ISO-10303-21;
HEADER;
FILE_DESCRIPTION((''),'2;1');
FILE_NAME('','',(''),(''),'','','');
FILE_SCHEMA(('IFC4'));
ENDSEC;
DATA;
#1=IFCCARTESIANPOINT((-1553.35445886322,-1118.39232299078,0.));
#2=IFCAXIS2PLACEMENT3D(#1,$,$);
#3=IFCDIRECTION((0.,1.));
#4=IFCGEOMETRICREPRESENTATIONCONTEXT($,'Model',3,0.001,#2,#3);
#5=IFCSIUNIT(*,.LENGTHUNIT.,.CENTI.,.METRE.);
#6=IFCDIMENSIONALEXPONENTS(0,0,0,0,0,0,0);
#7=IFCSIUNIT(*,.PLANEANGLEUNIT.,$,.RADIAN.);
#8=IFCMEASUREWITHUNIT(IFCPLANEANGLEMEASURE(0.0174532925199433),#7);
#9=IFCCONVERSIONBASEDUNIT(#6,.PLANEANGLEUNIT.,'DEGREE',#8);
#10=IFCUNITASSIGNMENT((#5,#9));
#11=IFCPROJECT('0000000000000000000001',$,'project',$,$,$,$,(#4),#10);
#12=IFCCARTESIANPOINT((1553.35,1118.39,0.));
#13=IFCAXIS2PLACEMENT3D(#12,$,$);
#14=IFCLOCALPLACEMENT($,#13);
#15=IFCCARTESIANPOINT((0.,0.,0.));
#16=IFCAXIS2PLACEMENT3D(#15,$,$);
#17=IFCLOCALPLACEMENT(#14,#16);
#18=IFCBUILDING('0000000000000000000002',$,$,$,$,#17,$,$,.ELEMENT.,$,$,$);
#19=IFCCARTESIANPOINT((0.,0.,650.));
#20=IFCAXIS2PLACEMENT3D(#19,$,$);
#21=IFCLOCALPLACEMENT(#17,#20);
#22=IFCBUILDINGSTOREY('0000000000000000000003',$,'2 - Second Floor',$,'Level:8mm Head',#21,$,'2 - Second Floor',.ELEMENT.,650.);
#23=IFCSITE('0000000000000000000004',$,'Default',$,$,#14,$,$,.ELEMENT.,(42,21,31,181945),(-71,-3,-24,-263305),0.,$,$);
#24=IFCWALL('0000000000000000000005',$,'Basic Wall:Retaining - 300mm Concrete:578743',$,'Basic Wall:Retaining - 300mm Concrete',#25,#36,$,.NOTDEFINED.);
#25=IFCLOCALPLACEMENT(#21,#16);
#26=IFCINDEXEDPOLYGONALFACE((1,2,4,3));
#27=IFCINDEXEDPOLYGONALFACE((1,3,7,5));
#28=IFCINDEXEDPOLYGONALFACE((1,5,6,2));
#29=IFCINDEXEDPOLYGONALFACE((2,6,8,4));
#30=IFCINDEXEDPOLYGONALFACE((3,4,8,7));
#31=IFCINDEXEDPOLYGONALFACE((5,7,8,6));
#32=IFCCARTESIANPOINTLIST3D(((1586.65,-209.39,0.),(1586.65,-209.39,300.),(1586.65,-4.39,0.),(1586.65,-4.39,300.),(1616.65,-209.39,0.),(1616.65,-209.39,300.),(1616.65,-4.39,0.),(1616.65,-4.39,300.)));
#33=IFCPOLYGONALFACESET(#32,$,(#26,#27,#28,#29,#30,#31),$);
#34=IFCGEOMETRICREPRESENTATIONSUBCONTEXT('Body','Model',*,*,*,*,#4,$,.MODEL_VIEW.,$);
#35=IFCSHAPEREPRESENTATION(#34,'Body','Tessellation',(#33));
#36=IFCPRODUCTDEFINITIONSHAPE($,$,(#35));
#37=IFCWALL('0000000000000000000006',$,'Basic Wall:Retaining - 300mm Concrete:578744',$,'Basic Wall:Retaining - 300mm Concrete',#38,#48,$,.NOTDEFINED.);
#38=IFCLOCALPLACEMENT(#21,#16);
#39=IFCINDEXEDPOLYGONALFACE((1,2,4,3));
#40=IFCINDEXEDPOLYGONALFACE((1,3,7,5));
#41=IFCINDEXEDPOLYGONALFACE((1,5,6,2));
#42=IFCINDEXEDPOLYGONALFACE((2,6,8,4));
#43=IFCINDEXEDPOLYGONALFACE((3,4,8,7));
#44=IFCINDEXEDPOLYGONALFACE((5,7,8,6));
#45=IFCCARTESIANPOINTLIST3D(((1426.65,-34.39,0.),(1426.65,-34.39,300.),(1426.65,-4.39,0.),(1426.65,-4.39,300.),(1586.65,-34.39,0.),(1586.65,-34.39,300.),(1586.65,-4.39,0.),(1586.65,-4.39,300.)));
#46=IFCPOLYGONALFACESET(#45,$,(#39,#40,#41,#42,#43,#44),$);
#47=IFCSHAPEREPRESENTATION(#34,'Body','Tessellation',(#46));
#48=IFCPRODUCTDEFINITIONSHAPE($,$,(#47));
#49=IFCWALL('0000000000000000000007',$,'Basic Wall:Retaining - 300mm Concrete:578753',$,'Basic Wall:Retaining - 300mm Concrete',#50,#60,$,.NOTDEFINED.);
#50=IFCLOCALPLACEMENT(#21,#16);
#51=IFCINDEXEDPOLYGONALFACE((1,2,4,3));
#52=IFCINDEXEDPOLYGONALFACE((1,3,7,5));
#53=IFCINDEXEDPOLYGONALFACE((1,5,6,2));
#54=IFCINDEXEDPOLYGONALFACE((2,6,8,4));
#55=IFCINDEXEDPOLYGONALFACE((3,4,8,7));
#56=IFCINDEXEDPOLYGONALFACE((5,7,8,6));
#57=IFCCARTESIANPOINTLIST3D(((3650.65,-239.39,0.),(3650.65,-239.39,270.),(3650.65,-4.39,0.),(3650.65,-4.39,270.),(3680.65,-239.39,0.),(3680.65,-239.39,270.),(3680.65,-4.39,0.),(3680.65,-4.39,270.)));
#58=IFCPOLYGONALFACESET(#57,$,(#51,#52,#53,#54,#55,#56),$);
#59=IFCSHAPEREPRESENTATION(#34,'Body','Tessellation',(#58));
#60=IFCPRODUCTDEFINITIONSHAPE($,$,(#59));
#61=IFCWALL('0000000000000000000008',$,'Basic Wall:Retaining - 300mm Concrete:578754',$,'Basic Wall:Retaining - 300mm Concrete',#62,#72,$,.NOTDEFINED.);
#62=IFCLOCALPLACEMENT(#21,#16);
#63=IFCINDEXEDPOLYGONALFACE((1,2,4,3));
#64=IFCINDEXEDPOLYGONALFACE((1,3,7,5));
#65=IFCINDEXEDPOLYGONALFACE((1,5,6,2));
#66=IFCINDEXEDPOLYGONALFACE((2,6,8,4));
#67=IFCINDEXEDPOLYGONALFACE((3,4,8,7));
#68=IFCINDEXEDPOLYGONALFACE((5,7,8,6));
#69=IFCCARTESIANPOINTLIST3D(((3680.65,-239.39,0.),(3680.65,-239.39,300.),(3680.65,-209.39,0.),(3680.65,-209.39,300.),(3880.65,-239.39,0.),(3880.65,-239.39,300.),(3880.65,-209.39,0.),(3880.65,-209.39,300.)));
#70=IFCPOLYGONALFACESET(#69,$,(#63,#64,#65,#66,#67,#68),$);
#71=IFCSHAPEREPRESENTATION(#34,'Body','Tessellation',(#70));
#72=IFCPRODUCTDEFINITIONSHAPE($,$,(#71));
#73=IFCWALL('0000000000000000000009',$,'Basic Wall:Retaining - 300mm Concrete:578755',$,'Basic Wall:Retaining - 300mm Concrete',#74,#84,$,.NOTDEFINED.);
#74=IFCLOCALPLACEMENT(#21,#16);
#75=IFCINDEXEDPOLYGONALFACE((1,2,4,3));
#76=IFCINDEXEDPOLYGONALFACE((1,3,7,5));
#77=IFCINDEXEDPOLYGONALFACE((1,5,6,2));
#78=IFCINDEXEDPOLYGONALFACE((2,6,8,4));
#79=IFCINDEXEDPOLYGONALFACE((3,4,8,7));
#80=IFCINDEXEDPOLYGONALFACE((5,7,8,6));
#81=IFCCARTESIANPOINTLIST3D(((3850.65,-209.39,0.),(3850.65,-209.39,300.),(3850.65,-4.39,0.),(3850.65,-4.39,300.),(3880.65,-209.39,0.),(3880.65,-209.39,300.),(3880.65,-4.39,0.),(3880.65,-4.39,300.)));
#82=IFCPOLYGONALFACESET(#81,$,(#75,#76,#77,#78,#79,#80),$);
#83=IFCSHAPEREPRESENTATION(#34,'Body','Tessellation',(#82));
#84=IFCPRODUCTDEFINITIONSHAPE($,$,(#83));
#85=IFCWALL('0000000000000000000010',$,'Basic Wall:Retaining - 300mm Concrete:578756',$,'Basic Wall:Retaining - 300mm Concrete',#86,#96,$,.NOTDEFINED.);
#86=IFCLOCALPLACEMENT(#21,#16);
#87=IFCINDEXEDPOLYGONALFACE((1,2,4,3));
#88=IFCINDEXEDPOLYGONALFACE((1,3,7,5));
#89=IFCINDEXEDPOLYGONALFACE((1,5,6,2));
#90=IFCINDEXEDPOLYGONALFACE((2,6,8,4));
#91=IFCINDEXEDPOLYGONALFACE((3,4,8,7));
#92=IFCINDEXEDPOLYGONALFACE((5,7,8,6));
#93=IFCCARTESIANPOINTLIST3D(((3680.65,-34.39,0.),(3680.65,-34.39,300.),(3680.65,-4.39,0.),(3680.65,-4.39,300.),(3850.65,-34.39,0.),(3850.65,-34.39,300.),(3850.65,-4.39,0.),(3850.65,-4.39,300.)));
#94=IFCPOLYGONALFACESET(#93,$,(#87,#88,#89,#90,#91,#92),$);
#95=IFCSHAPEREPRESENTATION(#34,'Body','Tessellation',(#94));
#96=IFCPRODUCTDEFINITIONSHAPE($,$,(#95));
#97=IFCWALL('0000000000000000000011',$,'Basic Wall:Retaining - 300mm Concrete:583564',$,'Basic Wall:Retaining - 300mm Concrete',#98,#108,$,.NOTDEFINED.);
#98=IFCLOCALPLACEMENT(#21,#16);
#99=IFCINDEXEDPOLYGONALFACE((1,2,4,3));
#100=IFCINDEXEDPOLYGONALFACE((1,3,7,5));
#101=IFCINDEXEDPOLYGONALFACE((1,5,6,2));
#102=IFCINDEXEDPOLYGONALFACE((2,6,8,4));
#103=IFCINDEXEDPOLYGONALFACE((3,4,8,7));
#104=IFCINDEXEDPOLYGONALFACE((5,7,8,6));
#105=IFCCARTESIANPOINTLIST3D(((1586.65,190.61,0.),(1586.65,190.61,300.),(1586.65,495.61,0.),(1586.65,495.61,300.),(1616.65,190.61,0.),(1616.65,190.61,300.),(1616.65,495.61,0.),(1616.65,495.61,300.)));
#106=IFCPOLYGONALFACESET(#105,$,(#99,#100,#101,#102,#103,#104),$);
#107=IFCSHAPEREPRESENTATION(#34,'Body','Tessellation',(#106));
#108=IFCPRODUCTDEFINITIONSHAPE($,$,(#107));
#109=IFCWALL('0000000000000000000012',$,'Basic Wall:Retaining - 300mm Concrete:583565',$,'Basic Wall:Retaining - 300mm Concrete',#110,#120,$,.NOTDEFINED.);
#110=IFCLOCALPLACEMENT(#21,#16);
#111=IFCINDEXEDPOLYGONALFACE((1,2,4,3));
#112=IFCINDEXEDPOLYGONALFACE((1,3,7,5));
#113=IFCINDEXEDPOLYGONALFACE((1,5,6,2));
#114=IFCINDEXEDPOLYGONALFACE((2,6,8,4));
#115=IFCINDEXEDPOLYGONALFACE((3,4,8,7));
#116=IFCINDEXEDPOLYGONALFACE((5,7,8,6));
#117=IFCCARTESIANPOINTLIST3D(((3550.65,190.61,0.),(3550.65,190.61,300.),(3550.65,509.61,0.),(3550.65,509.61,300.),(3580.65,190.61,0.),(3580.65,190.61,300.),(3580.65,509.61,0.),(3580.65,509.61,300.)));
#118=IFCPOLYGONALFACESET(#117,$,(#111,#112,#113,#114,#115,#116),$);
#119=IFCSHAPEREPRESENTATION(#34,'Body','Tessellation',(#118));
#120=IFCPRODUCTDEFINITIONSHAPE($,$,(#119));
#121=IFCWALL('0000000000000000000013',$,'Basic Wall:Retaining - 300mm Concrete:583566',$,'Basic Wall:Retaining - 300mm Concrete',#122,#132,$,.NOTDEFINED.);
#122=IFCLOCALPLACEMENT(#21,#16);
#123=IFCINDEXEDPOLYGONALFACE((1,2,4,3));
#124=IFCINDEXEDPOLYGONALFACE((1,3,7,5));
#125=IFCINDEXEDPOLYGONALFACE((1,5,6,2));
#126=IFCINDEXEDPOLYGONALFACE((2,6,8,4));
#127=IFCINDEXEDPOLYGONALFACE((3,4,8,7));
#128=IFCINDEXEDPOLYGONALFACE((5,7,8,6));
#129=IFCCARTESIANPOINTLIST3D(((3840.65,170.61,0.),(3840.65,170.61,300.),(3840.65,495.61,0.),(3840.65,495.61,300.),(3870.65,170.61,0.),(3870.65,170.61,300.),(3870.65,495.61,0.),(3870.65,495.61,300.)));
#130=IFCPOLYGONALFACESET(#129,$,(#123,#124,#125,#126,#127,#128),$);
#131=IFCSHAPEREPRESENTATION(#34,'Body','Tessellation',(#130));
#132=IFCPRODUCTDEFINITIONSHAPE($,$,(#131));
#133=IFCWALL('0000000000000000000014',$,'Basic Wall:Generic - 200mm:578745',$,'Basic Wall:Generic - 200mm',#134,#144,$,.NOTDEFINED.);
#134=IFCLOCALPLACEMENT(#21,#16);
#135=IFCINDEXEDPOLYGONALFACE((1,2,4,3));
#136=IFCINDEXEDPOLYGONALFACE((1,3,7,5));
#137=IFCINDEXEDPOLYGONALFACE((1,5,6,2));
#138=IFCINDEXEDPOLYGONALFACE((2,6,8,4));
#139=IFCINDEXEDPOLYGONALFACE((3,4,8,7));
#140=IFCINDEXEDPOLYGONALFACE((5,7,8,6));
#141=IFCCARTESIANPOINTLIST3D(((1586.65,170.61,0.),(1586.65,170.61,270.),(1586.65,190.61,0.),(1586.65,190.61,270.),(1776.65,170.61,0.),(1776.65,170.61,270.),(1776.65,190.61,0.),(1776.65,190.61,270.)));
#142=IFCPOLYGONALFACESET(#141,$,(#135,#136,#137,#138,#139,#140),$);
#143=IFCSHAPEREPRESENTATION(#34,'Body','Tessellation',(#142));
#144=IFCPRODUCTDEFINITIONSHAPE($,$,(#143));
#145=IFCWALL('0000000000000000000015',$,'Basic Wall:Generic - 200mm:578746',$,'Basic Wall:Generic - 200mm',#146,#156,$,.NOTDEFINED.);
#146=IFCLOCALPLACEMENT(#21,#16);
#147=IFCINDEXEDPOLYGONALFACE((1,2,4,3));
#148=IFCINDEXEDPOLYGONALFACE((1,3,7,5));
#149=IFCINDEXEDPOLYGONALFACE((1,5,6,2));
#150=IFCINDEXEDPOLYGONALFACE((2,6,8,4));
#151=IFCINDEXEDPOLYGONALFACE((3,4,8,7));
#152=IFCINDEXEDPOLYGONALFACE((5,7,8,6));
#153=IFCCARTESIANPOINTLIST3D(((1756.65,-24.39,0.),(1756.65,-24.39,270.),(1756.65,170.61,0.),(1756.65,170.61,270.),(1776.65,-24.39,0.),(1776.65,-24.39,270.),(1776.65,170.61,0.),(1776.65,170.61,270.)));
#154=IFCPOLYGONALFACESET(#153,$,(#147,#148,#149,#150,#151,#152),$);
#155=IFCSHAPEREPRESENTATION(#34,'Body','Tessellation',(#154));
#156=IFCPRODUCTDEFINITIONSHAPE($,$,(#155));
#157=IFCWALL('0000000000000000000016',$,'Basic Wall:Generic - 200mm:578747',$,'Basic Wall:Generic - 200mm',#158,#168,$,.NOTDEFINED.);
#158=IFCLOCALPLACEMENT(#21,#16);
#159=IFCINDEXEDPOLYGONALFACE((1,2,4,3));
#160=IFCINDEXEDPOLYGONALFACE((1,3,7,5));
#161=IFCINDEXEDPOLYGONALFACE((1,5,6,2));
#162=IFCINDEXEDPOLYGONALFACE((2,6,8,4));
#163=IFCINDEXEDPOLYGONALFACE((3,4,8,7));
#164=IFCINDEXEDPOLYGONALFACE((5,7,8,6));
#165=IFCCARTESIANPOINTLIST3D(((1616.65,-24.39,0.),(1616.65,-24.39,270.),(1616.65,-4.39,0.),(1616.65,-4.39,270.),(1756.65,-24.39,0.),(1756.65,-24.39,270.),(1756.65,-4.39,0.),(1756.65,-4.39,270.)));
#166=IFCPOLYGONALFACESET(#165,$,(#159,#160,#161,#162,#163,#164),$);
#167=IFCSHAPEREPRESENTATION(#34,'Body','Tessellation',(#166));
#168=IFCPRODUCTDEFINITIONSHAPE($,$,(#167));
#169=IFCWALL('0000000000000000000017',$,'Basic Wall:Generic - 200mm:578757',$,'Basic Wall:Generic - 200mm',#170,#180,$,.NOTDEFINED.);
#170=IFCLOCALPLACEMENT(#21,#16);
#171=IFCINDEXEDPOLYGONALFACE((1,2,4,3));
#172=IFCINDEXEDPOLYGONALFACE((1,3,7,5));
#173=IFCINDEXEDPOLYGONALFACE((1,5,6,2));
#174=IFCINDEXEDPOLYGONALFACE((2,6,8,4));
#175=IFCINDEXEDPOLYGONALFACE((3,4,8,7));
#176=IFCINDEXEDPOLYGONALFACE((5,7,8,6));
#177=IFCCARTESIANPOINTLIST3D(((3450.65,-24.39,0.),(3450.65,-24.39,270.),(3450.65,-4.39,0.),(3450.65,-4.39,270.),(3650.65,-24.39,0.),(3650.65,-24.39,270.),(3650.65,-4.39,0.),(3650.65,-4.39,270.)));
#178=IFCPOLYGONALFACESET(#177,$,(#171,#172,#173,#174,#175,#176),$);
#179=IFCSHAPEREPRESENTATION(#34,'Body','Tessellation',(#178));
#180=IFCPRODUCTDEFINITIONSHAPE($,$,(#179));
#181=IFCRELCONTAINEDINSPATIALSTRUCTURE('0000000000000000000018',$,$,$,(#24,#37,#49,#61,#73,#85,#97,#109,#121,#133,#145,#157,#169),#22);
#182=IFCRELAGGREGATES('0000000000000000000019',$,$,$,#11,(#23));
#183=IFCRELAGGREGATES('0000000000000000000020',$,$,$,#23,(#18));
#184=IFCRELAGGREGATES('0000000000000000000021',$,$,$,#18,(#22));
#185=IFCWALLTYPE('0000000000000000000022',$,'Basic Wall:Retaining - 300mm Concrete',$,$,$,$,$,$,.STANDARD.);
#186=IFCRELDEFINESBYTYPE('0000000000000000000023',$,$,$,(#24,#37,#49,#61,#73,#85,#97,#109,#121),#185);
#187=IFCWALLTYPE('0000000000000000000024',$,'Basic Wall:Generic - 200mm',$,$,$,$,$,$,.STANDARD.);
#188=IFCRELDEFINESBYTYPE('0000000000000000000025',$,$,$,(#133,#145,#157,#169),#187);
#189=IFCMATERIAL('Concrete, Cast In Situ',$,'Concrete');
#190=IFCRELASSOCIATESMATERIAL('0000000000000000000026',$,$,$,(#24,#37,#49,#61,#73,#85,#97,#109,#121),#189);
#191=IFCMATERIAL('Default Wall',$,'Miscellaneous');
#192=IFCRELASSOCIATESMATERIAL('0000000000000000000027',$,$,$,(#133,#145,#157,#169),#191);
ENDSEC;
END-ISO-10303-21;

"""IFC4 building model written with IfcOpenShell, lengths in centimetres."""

from ifc_helpers import new_model, entity, si_unit, converted_unit, direction, frame, origin, place, context, subcontext, project, spatial, indexed_curve, outline, extrude, material, type_object, element, save


model = new_model("IFC4")

# Units and contexts
model_context = context("Model", 3, precision=0.001, world=frame((-1553.35445886322, -1118.39232299078, 0.0)), true_north=direction((0.0, 1.0)))
body_context = subcontext(model_context, "Body", "Model", "MODEL_VIEW")
ifc_project = project(units=[si_unit("LENGTHUNIT", "METRE", prefix="CENTI"), converted_unit("PLANEANGLEUNIT", "DEGREE", entity("IfcPlaneAngleMeasure", 0.0174532925199433), si_unit("PLANEANGLEUNIT", "RADIAN"), dimensions=[0, 0, 0, 0, 0, 0, 0])], contexts=[model_context])

# Site, building, storey
site_placement = place(None, frame((1553.35, 1118.39, 0.0)))
site = spatial("IfcSite", under=ifc_project, at=site_placement, Name="Default", CompositionType="ELEMENT", RefLatitude=(42, 21, 31, 181945), RefLongitude=(-71, -3, -24, -263305), RefElevation=0.0)
building_placement = place(site_placement, origin())
building = spatial("IfcBuilding", under=site, at=building_placement, CompositionType="ELEMENT")
storey_placement = place(building_placement, frame((0.0, 0.0, 650.0)))
storey = spatial("IfcBuildingStorey", under=building, at=storey_placement, Name="2 - Second Floor", ObjectType="Level:8mm Head", LongName="2 - Second Floor", CompositionType="ELEMENT", Elevation=650.0)

# Walls
ifc_material_1 = material(Name="Concrete, Cast In Situ", Category="Concrete")
wall_type_1 = type_object("IfcWallType", Name="Basic Wall:Retaining - 300mm Concrete", PredefinedType="STANDARD")
wall_1_placement = place(storey_placement, frame((1601.65, -209.39, 0.0), z_axis=(0.0, 0.0, 1.0), x_axis=(0.0, 1.0, 0.0)))
element("IfcWall", 1, at=wall_1_placement, inside=storey, type_object=wall_type_1, material=ifc_material_1, Name="Basic Wall:Retaining - 300mm Concrete:578743", ObjectType="Basic Wall:Retaining - 300mm Concrete", PredefinedType="NOTDEFINED", context=body_context, shape_type="SweptSolid", body=[
    extrude(outline(indexed_curve([(205.0, 15.0), (0.0, 15.0), (0.0, -15.0), (205.0, -15.0), (205.0, 15.0)], self_intersect=False)), origin(), (0.0, 0.0, 1.0), 300.0),
])
wall_2_placement = place(storey_placement, frame((1586.65, -19.39, 0.0), z_axis=(0.0, 0.0, 1.0), x_axis=(-1.0, 0.0, 0.0)))
element("IfcWall", 2, at=wall_2_placement, inside=storey, type_object=wall_type_1, material=ifc_material_1, Name="Basic Wall:Retaining - 300mm Concrete:578744", ObjectType="Basic Wall:Retaining - 300mm Concrete", PredefinedType="NOTDEFINED", context=body_context, shape_type="SweptSolid", body=[
    extrude(outline(indexed_curve([(160.0, 15.0), (0.0, 15.0), (0.0, -15.0), (160.0, -15.0), (160.0, 15.0)], self_intersect=False)), origin(), (0.0, 0.0, 1.0), 300.0),
])
wall_3_placement = place(storey_placement, frame((3665.65, -4.39, 0.0), z_axis=(0.0, 0.0, 1.0), x_axis=(0.0, -1.0, 0.0)))
element("IfcWall", 3, at=wall_3_placement, inside=storey, type_object=wall_type_1, material=ifc_material_1, Name="Basic Wall:Retaining - 300mm Concrete:578753", ObjectType="Basic Wall:Retaining - 300mm Concrete", PredefinedType="NOTDEFINED", context=body_context, shape_type="SweptSolid", body=[
    extrude(outline(indexed_curve([(235.0, 15.0), (0.0, 15.0), (0.0, -15.0), (235.0, -15.0), (235.0, 15.0)], self_intersect=False)), origin(), (0.0, 0.0, 1.0), 270.0),
])
wall_4_placement = place(storey_placement, frame((3680.65, -224.39, 0.0)))
element("IfcWall", 4, at=wall_4_placement, inside=storey, type_object=wall_type_1, material=ifc_material_1, Name="Basic Wall:Retaining - 300mm Concrete:578754", ObjectType="Basic Wall:Retaining - 300mm Concrete", PredefinedType="NOTDEFINED", context=body_context, shape_type="SweptSolid", body=[
    extrude(outline(indexed_curve([(200.0, 15.0), (0.0, 15.0), (0.0, -15.0), (200.0, -15.0), (200.0, 15.0)], self_intersect=False)), origin(), (0.0, 0.0, 1.0), 300.0),
])
wall_5_placement = place(storey_placement, frame((3865.65, -209.39, 0.0), z_axis=(0.0, 0.0, 1.0), x_axis=(0.0, 1.0, 0.0)))
element("IfcWall", 5, at=wall_5_placement, inside=storey, type_object=wall_type_1, material=ifc_material_1, Name="Basic Wall:Retaining - 300mm Concrete:578755", ObjectType="Basic Wall:Retaining - 300mm Concrete", PredefinedType="NOTDEFINED", context=body_context, shape_type="SweptSolid", body=[
    extrude(outline(indexed_curve([(205.0, 15.0), (0.0, 15.0), (0.0, -15.0), (205.0, -15.0), (205.0, 15.0)], self_intersect=False)), origin(), (0.0, 0.0, 1.0), 300.0),
])
wall_6_placement = place(storey_placement, frame((3850.65, -19.39, 0.0), z_axis=(0.0, 0.0, 1.0), x_axis=(-1.0, 0.0, 0.0)))
element("IfcWall", 6, at=wall_6_placement, inside=storey, type_object=wall_type_1, material=ifc_material_1, Name="Basic Wall:Retaining - 300mm Concrete:578756", ObjectType="Basic Wall:Retaining - 300mm Concrete", PredefinedType="NOTDEFINED", context=body_context, shape_type="SweptSolid", body=[
    extrude(outline(indexed_curve([(170.0, 15.0), (0.0, 15.0), (0.0, -15.0), (170.0, -15.0), (170.0, 15.0)], self_intersect=False)), origin(), (0.0, 0.0, 1.0), 300.0),
])
wall_7_placement = place(storey_placement, frame((1601.65, 495.61, 0.0), z_axis=(0.0, 0.0, 1.0), x_axis=(0.0, -1.0, 0.0)))
element("IfcWall", 7, at=wall_7_placement, inside=storey, type_object=wall_type_1, material=ifc_material_1, Name="Basic Wall:Retaining - 300mm Concrete:583564", ObjectType="Basic Wall:Retaining - 300mm Concrete", PredefinedType="NOTDEFINED", context=body_context, shape_type="SweptSolid", body=[
    extrude(outline(indexed_curve([(305.0, 15.0), (0.0, 15.0), (0.0, -15.0), (305.0, -15.0), (305.0, 15.0)], self_intersect=False)), origin(), (0.0, 0.0, 1.0), 300.0),
])
wall_8_placement = place(storey_placement, frame((3565.65, 509.61, 0.0), z_axis=(0.0, 0.0, 1.0), x_axis=(0.0, -1.0, 0.0)))
element("IfcWall", 8, at=wall_8_placement, inside=storey, type_object=wall_type_1, material=ifc_material_1, Name="Basic Wall:Retaining - 300mm Concrete:583565", ObjectType="Basic Wall:Retaining - 300mm Concrete", PredefinedType="NOTDEFINED", context=body_context, shape_type="SweptSolid", body=[
    extrude(outline(indexed_curve([(319.0, 15.0), (0.0, 15.0), (0.0, -15.0), (319.0, -15.0), (319.0, 15.0)], self_intersect=False)), origin(), (0.0, 0.0, 1.0), 300.0),
])
wall_9_placement = place(storey_placement, frame((3855.65, 495.61, 0.0), z_axis=(0.0, 0.0, 1.0), x_axis=(0.0, -1.0, 0.0)))
element("IfcWall", 9, at=wall_9_placement, inside=storey, type_object=wall_type_1, material=ifc_material_1, Name="Basic Wall:Retaining - 300mm Concrete:583566", ObjectType="Basic Wall:Retaining - 300mm Concrete", PredefinedType="NOTDEFINED", context=body_context, shape_type="SweptSolid", body=[
    extrude(outline(indexed_curve([(325.0, 15.0), (0.0, 15.0), (0.0, -15.0), (325.0, -15.0), (325.0, 15.0)], self_intersect=False)), origin(), (0.0, 0.0, 1.0), 300.0),
])
ifc_material_2 = material(Name="Default Wall", Category="Miscellaneous")
wall_type_2 = type_object("IfcWallType", Name="Basic Wall:Generic - 200mm", PredefinedType="STANDARD")
wall_10_placement = place(storey_placement, frame((1586.65, 180.61, 0.0)))
element("IfcWall", 10, at=wall_10_placement, inside=storey, type_object=wall_type_2, material=ifc_material_2, Name="Basic Wall:Generic - 200mm:578745", ObjectType="Basic Wall:Generic - 200mm", PredefinedType="NOTDEFINED", context=body_context, shape_type="SweptSolid", body=[
    extrude(outline(indexed_curve([(190.0, 10.0), (0.0, 10.0), (0.0, -10.0), (190.0, -10.0), (190.0, 10.0)], self_intersect=False)), origin(), (0.0, 0.0, 1.0), 270.0),
])
wall_11_placement = place(storey_placement, frame((1766.65, 170.61, 0.0), z_axis=(0.0, 0.0, 1.0), x_axis=(0.0, -1.0, 0.0)))
element("IfcWall", 11, at=wall_11_placement, inside=storey, type_object=wall_type_2, material=ifc_material_2, Name="Basic Wall:Generic - 200mm:578746", ObjectType="Basic Wall:Generic - 200mm", PredefinedType="NOTDEFINED", context=body_context, shape_type="SweptSolid", body=[
    extrude(outline(indexed_curve([(195.0, 10.0), (0.0, 10.0), (0.0, -10.0), (195.0, -10.0), (195.0, 10.0)], self_intersect=False)), origin(), (0.0, 0.0, 1.0), 270.0),
])
wall_12_placement = place(storey_placement, frame((1616.65, -14.39, 0.0)))
element("IfcWall", 12, at=wall_12_placement, inside=storey, type_object=wall_type_2, material=ifc_material_2, Name="Basic Wall:Generic - 200mm:578747", ObjectType="Basic Wall:Generic - 200mm", PredefinedType="NOTDEFINED", context=body_context, shape_type="SweptSolid", body=[
    extrude(outline(indexed_curve([(140.0, 10.0), (0.0, 10.0), (0.0, -10.0), (140.0, -10.0), (140.0, 10.0)], self_intersect=False)), origin(), (0.0, 0.0, 1.0), 270.0),
])
wall_13_placement = place(storey_placement, frame((3650.65, -14.39, 0.0), z_axis=(0.0, 0.0, 1.0), x_axis=(-1.0, 0.0, 0.0)))
element("IfcWall", 13, at=wall_13_placement, inside=storey, type_object=wall_type_2, material=ifc_material_2, Name="Basic Wall:Generic - 200mm:578757", ObjectType="Basic Wall:Generic - 200mm", PredefinedType="NOTDEFINED", context=body_context, shape_type="SweptSolid", body=[
    extrude(outline(indexed_curve([(200.0, 10.0), (0.0, 10.0), (0.0, -10.0), (200.0, -10.0), (200.0, 10.0)], self_intersect=False)), origin(), (0.0, 0.0, 1.0), 270.0),
])

save(model, "model.ifc")
